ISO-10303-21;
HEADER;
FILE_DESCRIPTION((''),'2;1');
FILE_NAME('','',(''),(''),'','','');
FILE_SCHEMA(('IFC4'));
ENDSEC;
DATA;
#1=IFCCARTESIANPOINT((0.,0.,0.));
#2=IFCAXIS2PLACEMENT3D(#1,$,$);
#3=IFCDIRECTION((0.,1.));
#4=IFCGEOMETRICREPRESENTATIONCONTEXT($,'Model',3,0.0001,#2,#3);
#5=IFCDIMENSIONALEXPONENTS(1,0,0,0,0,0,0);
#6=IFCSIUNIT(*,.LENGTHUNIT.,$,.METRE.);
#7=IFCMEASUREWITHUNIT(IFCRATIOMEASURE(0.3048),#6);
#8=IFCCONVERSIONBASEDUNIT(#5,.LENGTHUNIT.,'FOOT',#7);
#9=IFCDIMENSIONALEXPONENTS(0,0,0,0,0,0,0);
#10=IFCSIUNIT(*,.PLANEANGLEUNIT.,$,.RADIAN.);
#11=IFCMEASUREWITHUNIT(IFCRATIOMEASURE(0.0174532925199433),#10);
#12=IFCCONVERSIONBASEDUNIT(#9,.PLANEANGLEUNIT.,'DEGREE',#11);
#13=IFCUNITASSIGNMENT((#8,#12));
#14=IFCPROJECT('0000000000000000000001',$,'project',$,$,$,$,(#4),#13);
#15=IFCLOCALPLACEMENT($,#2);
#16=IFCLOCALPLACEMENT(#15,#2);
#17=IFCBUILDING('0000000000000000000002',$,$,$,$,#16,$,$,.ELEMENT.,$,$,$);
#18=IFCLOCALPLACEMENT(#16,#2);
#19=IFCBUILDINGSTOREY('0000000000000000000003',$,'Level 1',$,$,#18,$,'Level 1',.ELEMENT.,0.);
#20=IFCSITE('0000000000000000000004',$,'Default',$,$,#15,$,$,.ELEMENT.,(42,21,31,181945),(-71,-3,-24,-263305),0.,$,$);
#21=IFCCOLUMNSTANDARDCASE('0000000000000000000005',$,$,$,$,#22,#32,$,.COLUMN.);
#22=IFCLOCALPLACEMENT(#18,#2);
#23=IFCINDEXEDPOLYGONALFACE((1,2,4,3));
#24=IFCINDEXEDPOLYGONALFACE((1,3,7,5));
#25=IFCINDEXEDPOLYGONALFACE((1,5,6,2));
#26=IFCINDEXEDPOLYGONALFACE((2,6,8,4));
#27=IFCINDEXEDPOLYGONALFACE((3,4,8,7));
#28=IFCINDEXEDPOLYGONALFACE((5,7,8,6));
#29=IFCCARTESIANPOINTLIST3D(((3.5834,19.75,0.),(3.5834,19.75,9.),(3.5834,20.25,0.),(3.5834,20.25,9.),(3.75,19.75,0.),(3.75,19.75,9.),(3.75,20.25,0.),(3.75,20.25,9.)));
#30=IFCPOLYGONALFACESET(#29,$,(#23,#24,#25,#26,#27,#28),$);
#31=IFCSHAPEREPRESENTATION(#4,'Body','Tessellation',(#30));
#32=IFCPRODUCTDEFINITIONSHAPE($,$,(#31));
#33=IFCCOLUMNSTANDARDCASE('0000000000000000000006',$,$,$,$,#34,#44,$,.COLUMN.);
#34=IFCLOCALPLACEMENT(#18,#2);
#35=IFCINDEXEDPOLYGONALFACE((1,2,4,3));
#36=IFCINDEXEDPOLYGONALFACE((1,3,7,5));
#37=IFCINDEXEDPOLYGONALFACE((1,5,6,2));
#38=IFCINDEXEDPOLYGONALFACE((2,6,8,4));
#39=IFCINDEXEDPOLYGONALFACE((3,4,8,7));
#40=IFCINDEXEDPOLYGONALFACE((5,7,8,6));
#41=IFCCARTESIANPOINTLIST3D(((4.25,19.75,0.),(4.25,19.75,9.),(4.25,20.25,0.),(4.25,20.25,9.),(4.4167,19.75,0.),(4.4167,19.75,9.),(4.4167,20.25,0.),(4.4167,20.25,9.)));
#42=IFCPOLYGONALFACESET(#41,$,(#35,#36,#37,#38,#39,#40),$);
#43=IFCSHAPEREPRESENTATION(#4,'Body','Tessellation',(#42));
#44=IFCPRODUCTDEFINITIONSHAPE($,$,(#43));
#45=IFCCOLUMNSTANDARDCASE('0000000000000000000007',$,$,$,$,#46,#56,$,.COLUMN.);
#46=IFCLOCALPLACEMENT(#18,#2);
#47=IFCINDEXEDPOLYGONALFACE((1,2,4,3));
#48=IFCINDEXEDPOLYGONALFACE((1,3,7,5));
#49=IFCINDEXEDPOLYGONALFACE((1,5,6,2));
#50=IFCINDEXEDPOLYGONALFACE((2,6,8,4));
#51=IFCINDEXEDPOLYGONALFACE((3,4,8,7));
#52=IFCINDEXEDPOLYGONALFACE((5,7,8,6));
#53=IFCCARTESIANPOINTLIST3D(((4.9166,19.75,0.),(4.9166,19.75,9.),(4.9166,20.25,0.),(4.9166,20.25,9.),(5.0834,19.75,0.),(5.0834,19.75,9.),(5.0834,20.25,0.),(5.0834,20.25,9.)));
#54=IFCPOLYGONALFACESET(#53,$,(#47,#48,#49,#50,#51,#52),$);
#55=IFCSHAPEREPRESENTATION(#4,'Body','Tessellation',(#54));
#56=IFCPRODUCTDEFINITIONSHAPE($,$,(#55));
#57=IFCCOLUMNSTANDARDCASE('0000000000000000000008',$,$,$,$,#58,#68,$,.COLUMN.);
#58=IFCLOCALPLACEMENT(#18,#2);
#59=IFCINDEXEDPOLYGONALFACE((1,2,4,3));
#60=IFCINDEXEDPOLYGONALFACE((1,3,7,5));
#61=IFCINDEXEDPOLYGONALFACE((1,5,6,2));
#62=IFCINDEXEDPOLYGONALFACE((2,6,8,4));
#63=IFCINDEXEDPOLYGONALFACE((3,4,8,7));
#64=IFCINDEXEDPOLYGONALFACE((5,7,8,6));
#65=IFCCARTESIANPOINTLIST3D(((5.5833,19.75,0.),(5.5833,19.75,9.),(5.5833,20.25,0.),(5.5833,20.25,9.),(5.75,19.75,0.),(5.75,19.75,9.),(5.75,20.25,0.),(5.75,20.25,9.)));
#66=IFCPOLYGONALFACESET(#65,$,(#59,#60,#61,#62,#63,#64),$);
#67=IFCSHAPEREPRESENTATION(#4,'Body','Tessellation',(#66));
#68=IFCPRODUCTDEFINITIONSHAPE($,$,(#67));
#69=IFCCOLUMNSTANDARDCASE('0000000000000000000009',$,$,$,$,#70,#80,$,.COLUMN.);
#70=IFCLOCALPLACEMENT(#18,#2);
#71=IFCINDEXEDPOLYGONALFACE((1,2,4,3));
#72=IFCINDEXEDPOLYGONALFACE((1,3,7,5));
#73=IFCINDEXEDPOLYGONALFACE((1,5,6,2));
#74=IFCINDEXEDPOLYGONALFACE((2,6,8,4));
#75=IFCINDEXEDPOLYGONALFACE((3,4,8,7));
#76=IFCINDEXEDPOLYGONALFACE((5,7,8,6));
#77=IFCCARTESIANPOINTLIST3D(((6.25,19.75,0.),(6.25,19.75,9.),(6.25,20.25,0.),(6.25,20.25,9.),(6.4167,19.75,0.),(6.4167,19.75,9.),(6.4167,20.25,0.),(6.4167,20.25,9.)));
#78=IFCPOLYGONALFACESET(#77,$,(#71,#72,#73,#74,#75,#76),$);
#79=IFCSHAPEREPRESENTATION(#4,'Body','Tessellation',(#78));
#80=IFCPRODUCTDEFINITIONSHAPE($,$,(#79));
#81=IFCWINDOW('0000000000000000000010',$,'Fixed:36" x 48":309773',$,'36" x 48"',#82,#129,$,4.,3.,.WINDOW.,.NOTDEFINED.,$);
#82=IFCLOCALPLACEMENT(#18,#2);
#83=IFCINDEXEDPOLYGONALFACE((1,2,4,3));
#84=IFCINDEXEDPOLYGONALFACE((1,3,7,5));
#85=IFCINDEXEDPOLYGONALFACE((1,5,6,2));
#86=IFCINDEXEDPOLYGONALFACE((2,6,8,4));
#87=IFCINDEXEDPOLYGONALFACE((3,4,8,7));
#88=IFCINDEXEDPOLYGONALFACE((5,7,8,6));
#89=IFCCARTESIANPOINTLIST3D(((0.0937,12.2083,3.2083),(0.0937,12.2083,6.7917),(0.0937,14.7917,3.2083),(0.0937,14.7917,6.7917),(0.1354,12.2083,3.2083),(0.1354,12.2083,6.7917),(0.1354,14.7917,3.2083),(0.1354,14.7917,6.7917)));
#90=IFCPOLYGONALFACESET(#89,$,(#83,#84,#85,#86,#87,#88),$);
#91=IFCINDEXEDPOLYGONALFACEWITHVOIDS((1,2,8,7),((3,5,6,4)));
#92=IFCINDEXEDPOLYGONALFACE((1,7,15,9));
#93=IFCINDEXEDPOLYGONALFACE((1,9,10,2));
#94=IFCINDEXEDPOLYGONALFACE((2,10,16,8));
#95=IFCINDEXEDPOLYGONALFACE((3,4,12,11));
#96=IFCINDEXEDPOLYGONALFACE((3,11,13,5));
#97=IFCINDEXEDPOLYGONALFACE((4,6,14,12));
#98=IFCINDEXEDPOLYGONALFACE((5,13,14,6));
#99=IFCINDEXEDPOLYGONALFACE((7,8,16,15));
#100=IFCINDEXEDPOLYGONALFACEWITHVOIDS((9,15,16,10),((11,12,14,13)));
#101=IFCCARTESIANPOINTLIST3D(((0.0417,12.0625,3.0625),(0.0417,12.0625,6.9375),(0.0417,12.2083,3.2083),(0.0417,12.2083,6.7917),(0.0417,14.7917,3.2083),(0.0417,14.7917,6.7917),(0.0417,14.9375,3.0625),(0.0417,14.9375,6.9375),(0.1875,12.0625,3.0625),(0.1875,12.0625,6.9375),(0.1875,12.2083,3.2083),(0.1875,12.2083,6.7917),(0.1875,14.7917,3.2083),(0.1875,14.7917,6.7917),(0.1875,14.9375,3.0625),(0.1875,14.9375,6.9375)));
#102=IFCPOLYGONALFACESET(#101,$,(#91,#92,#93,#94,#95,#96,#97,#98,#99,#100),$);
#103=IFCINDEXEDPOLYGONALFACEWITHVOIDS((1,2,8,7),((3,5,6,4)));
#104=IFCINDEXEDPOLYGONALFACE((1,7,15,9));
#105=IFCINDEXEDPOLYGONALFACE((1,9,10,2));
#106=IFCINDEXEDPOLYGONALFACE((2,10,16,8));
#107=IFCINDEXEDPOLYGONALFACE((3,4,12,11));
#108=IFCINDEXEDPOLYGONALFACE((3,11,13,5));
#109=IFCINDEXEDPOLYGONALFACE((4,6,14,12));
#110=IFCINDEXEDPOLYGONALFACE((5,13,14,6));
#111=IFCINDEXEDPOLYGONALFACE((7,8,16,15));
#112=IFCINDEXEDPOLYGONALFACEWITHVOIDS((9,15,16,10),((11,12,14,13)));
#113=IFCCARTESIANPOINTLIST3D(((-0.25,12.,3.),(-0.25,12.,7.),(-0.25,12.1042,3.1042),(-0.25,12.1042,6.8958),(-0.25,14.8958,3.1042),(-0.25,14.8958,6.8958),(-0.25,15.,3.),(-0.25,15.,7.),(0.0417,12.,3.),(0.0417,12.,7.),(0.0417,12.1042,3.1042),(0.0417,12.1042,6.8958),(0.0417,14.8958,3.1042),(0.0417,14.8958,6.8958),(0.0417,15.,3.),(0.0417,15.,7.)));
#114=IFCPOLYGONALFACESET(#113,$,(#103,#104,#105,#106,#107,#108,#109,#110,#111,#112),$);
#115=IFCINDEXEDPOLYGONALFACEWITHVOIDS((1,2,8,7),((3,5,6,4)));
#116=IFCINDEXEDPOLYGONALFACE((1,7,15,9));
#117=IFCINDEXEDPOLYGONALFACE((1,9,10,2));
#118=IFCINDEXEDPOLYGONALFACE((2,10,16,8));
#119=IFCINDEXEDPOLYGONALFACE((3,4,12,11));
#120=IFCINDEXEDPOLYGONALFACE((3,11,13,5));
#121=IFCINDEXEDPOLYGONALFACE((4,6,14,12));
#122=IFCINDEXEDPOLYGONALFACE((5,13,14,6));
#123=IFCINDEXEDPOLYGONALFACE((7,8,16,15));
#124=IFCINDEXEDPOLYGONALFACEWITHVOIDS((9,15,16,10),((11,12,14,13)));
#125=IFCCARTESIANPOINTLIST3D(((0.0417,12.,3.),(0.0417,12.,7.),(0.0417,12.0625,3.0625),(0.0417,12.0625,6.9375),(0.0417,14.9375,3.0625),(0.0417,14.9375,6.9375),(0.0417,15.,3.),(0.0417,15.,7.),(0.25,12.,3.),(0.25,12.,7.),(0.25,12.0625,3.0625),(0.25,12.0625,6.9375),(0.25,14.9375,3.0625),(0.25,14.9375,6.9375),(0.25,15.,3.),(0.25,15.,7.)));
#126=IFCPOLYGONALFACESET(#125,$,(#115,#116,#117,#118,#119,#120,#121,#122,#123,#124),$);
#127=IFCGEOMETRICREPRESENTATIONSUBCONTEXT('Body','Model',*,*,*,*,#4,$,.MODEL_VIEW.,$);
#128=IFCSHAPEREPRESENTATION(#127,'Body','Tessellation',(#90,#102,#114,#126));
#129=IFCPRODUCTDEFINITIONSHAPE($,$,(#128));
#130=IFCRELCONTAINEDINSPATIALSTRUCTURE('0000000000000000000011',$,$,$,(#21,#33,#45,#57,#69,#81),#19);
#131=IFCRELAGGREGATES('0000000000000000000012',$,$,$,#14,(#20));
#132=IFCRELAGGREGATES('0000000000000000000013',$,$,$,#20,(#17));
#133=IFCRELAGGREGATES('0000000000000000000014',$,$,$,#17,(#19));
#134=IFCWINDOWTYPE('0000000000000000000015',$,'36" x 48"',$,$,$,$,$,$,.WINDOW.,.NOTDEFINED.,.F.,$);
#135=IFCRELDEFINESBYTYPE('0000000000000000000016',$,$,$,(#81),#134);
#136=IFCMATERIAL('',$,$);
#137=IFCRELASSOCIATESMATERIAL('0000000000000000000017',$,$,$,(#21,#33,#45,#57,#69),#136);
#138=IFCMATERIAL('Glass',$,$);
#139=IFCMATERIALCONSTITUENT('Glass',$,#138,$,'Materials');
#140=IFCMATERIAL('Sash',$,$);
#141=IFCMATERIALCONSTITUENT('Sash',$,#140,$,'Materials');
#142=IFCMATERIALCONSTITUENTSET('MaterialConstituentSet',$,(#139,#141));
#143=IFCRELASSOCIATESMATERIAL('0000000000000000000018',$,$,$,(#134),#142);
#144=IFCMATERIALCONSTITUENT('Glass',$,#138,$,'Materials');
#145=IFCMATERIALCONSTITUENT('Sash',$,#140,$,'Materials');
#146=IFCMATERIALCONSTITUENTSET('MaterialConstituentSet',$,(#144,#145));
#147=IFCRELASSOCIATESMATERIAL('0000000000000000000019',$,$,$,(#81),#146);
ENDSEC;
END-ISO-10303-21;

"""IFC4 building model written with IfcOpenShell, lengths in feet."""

from ifc_helpers import new_model, entity, si_unit, converted_unit, direction, frame, frame_2d, origin, place, context, subcontext, project, spatial, polyline, rectangle, outline, extrude, source, transform, mapped, material, constituent, constituent_set, type_object, type_shapes, element, save


model = new_model("IFC4")

# Units and contexts
model_context = context("Model", 3, precision=0.0001, world=origin(), true_north=direction((0.0, 1.0)))
body_context = subcontext(model_context, "Body", "Model", "MODEL_VIEW")
ifc_project = project(units=[converted_unit("LENGTHUNIT", "FOOT", entity("IfcRatioMeasure", 0.3048), si_unit("LENGTHUNIT", "METRE"), dimensions=[1, 0, 0, 0, 0, 0, 0]), converted_unit("PLANEANGLEUNIT", "DEGREE", entity("IfcRatioMeasure", 0.0174532925199433), si_unit("PLANEANGLEUNIT", "RADIAN"), dimensions=[0, 0, 0, 0, 0, 0, 0])], contexts=[model_context])

# Site, building, storey
site_placement = place(None, origin())
site = spatial("IfcSite", under=ifc_project, at=site_placement, Name="Default", CompositionType="ELEMENT", RefLatitude=(42, 21, 31, 181945), RefLongitude=(-71, -3, -24, -263305), RefElevation=0.0)
building_placement = place(site_placement, origin())
building = spatial("IfcBuilding", under=site, at=building_placement, CompositionType="ELEMENT")
storey_placement = place(building_placement, origin())
storey = spatial("IfcBuildingStorey", under=building, at=storey_placement, Name="Level 1", LongName="Level 1", CompositionType="ELEMENT", Elevation=0.0)

# Columns
placement_1 = place(storey_placement, frame((0.0, -0.25, 0.0), z_axis=(0.0, 0.0, 1.0), x_axis=(0.0, 1.0, 0.0)))
ifc_material_1 = material(Name="")
placement_2 = place(storey_placement, frame((0.25, 20.0, 0.0)))
for number, where, z_axis, x_axis in (
    (1, (3.4167, 0.0, 0.0), (0.0, 0.0, 1.0), (1.0, 0.0, 0.0)),
    (2, (4.0833, 0.0, 0.0), (0.0, 0.0, 1.0), (1.0, 0.0, 0.0)),
    (3, (4.75, 0.0, 0.0), (0.0, 0.0, 1.0), (1.0, 0.0, 0.0)),
    (4, (5.4167, 0.0, 0.0), (0.0, 0.0, 1.0), (1.0, 0.0, 0.0)),
    (5, (6.0833, 0.0, 0.0), (0.0, 0.0, 1.0), (1.0, 0.0, 0.0)),
):
    element("IfcColumnStandardCase", number, at=place(placement_2, frame(where, z_axis=z_axis, x_axis=x_axis)), inside=storey, material=ifc_material_1, PredefinedType="COLUMN", context=model_context, shape_type="SweptSolid", body=[
        extrude(rectangle(XDim=0.1667, YDim=0.5), origin(), (0.0, 0.0, 1.0), 9.0),
    ])

# Window
ifc_material_2 = material(Name="Glass")
ifc_constituent_1 = constituent(ifc_material_2, Name="Glass", Category="Materials")
ifc_material_3 = material(Name="Sash")
ifc_constituent_2 = constituent(ifc_material_3, Name="Sash", Category="Materials")
ifc_constituent_set_1 = constituent_set(constituents=[ifc_constituent_1, ifc_constituent_2], Name="MaterialConstituentSet")
ifc_constituent_3 = constituent(ifc_material_2, Name="Glass", Category="Materials")
ifc_constituent_4 = constituent(ifc_material_3, Name="Sash", Category="Materials")
ifc_constituent_set_2 = constituent_set(constituents=[ifc_constituent_3, ifc_constituent_4], Name="MaterialConstituentSet")
window_type = type_object("IfcWindowType", Name="36\" x 48\"", ParameterTakesPrecedence=False, PartitioningType="NOTDEFINED", PredefinedType="WINDOW", material=ifc_constituent_set_2)
shared_shape = source(origin(), body_context, "Body", "SweptSolid", [
    extrude(rectangle(XDim=0.0417, YDim=2.5833, at=frame_2d((0.0, 0.0), x_axis=(1.0, 0.0))), frame((1.5, 0.3646, 0.2083), z_axis=(0.0, 0.0, 1.0), x_axis=(0.0, 1.0, 0.0)), (0.0, 0.0, 1.0), 3.5833),
    extrude(outline(polyline([(-1.4375, -1.9375), (1.4375, -1.9375), (1.4375, 1.9375), (-1.4375, 1.9375), (-1.4375, -1.9375)]), holes=[polyline([(-1.2917, -1.7917), (-1.2917, 1.7917), (1.2917, 1.7917), (1.2917, -1.7917), (-1.2917, -1.7917)])]), frame((1.5, 0.2917, 2.0), z_axis=(0.0, 1.0, 0.0), x_axis=(1.0, 0.0, 0.0)), (0.0, 0.0, 1.0), 0.1458),
    extrude(outline(polyline([(-1.5, -2.0), (1.5, -2.0), (1.5, 2.0), (-1.5, 2.0), (-1.5, -2.0)]), holes=[polyline([(-1.3958, -1.8958), (-1.3958, 1.8958), (1.3958, 1.8958), (1.3958, -1.8958), (-1.3958, -1.8958)])]), frame((1.5, 0.0, 2.0), z_axis=(0.0, 1.0, 0.0), x_axis=(1.0, 0.0, 0.0)), (0.0, 0.0, 1.0), 0.2917),
    extrude(outline(polyline([(-2.0, -1.5), (2.0, -1.5), (2.0, 1.5), (-2.0, 1.5), (-2.0, -1.5)]), holes=[polyline([(-1.9375, -1.4375), (-1.9375, 1.4375), (1.9375, 1.4375), (1.9375, -1.4375), (-1.9375, -1.4375)])]), frame((1.5, 0.2917, 2.0), z_axis=(0.0, 1.0, 0.0), x_axis=(0.0, 0.0, -1.0)), (0.0, 0.0, 1.0), 0.2083),
])
type_shapes(window_type, [shared_shape])
placement_3 = place(placement_1, frame((15.25, 0.25, 3.0)))
window_placement = place(placement_3, frame((0.0, 0.0, 0.0), z_axis=(0.0, 0.0, 1.0), x_axis=(-1.0, 0.0, 0.0)))
element("IfcWindow", 6, at=window_placement, inside=storey, type_object=window_type, material=ifc_constituent_set_1, Name="Fixed:36\" x 48\":309773", ObjectType="36\" x 48\"", OverallHeight=4.0, OverallWidth=3.0, PartitioningType="NOTDEFINED", PredefinedType="WINDOW", context=body_context, shape_type="MappedRepresentation", body=[
    mapped(shared_shape, transform((0.0, 0.0, 0.0), scale=1.0)),
])

save(model, "model.ifc")
